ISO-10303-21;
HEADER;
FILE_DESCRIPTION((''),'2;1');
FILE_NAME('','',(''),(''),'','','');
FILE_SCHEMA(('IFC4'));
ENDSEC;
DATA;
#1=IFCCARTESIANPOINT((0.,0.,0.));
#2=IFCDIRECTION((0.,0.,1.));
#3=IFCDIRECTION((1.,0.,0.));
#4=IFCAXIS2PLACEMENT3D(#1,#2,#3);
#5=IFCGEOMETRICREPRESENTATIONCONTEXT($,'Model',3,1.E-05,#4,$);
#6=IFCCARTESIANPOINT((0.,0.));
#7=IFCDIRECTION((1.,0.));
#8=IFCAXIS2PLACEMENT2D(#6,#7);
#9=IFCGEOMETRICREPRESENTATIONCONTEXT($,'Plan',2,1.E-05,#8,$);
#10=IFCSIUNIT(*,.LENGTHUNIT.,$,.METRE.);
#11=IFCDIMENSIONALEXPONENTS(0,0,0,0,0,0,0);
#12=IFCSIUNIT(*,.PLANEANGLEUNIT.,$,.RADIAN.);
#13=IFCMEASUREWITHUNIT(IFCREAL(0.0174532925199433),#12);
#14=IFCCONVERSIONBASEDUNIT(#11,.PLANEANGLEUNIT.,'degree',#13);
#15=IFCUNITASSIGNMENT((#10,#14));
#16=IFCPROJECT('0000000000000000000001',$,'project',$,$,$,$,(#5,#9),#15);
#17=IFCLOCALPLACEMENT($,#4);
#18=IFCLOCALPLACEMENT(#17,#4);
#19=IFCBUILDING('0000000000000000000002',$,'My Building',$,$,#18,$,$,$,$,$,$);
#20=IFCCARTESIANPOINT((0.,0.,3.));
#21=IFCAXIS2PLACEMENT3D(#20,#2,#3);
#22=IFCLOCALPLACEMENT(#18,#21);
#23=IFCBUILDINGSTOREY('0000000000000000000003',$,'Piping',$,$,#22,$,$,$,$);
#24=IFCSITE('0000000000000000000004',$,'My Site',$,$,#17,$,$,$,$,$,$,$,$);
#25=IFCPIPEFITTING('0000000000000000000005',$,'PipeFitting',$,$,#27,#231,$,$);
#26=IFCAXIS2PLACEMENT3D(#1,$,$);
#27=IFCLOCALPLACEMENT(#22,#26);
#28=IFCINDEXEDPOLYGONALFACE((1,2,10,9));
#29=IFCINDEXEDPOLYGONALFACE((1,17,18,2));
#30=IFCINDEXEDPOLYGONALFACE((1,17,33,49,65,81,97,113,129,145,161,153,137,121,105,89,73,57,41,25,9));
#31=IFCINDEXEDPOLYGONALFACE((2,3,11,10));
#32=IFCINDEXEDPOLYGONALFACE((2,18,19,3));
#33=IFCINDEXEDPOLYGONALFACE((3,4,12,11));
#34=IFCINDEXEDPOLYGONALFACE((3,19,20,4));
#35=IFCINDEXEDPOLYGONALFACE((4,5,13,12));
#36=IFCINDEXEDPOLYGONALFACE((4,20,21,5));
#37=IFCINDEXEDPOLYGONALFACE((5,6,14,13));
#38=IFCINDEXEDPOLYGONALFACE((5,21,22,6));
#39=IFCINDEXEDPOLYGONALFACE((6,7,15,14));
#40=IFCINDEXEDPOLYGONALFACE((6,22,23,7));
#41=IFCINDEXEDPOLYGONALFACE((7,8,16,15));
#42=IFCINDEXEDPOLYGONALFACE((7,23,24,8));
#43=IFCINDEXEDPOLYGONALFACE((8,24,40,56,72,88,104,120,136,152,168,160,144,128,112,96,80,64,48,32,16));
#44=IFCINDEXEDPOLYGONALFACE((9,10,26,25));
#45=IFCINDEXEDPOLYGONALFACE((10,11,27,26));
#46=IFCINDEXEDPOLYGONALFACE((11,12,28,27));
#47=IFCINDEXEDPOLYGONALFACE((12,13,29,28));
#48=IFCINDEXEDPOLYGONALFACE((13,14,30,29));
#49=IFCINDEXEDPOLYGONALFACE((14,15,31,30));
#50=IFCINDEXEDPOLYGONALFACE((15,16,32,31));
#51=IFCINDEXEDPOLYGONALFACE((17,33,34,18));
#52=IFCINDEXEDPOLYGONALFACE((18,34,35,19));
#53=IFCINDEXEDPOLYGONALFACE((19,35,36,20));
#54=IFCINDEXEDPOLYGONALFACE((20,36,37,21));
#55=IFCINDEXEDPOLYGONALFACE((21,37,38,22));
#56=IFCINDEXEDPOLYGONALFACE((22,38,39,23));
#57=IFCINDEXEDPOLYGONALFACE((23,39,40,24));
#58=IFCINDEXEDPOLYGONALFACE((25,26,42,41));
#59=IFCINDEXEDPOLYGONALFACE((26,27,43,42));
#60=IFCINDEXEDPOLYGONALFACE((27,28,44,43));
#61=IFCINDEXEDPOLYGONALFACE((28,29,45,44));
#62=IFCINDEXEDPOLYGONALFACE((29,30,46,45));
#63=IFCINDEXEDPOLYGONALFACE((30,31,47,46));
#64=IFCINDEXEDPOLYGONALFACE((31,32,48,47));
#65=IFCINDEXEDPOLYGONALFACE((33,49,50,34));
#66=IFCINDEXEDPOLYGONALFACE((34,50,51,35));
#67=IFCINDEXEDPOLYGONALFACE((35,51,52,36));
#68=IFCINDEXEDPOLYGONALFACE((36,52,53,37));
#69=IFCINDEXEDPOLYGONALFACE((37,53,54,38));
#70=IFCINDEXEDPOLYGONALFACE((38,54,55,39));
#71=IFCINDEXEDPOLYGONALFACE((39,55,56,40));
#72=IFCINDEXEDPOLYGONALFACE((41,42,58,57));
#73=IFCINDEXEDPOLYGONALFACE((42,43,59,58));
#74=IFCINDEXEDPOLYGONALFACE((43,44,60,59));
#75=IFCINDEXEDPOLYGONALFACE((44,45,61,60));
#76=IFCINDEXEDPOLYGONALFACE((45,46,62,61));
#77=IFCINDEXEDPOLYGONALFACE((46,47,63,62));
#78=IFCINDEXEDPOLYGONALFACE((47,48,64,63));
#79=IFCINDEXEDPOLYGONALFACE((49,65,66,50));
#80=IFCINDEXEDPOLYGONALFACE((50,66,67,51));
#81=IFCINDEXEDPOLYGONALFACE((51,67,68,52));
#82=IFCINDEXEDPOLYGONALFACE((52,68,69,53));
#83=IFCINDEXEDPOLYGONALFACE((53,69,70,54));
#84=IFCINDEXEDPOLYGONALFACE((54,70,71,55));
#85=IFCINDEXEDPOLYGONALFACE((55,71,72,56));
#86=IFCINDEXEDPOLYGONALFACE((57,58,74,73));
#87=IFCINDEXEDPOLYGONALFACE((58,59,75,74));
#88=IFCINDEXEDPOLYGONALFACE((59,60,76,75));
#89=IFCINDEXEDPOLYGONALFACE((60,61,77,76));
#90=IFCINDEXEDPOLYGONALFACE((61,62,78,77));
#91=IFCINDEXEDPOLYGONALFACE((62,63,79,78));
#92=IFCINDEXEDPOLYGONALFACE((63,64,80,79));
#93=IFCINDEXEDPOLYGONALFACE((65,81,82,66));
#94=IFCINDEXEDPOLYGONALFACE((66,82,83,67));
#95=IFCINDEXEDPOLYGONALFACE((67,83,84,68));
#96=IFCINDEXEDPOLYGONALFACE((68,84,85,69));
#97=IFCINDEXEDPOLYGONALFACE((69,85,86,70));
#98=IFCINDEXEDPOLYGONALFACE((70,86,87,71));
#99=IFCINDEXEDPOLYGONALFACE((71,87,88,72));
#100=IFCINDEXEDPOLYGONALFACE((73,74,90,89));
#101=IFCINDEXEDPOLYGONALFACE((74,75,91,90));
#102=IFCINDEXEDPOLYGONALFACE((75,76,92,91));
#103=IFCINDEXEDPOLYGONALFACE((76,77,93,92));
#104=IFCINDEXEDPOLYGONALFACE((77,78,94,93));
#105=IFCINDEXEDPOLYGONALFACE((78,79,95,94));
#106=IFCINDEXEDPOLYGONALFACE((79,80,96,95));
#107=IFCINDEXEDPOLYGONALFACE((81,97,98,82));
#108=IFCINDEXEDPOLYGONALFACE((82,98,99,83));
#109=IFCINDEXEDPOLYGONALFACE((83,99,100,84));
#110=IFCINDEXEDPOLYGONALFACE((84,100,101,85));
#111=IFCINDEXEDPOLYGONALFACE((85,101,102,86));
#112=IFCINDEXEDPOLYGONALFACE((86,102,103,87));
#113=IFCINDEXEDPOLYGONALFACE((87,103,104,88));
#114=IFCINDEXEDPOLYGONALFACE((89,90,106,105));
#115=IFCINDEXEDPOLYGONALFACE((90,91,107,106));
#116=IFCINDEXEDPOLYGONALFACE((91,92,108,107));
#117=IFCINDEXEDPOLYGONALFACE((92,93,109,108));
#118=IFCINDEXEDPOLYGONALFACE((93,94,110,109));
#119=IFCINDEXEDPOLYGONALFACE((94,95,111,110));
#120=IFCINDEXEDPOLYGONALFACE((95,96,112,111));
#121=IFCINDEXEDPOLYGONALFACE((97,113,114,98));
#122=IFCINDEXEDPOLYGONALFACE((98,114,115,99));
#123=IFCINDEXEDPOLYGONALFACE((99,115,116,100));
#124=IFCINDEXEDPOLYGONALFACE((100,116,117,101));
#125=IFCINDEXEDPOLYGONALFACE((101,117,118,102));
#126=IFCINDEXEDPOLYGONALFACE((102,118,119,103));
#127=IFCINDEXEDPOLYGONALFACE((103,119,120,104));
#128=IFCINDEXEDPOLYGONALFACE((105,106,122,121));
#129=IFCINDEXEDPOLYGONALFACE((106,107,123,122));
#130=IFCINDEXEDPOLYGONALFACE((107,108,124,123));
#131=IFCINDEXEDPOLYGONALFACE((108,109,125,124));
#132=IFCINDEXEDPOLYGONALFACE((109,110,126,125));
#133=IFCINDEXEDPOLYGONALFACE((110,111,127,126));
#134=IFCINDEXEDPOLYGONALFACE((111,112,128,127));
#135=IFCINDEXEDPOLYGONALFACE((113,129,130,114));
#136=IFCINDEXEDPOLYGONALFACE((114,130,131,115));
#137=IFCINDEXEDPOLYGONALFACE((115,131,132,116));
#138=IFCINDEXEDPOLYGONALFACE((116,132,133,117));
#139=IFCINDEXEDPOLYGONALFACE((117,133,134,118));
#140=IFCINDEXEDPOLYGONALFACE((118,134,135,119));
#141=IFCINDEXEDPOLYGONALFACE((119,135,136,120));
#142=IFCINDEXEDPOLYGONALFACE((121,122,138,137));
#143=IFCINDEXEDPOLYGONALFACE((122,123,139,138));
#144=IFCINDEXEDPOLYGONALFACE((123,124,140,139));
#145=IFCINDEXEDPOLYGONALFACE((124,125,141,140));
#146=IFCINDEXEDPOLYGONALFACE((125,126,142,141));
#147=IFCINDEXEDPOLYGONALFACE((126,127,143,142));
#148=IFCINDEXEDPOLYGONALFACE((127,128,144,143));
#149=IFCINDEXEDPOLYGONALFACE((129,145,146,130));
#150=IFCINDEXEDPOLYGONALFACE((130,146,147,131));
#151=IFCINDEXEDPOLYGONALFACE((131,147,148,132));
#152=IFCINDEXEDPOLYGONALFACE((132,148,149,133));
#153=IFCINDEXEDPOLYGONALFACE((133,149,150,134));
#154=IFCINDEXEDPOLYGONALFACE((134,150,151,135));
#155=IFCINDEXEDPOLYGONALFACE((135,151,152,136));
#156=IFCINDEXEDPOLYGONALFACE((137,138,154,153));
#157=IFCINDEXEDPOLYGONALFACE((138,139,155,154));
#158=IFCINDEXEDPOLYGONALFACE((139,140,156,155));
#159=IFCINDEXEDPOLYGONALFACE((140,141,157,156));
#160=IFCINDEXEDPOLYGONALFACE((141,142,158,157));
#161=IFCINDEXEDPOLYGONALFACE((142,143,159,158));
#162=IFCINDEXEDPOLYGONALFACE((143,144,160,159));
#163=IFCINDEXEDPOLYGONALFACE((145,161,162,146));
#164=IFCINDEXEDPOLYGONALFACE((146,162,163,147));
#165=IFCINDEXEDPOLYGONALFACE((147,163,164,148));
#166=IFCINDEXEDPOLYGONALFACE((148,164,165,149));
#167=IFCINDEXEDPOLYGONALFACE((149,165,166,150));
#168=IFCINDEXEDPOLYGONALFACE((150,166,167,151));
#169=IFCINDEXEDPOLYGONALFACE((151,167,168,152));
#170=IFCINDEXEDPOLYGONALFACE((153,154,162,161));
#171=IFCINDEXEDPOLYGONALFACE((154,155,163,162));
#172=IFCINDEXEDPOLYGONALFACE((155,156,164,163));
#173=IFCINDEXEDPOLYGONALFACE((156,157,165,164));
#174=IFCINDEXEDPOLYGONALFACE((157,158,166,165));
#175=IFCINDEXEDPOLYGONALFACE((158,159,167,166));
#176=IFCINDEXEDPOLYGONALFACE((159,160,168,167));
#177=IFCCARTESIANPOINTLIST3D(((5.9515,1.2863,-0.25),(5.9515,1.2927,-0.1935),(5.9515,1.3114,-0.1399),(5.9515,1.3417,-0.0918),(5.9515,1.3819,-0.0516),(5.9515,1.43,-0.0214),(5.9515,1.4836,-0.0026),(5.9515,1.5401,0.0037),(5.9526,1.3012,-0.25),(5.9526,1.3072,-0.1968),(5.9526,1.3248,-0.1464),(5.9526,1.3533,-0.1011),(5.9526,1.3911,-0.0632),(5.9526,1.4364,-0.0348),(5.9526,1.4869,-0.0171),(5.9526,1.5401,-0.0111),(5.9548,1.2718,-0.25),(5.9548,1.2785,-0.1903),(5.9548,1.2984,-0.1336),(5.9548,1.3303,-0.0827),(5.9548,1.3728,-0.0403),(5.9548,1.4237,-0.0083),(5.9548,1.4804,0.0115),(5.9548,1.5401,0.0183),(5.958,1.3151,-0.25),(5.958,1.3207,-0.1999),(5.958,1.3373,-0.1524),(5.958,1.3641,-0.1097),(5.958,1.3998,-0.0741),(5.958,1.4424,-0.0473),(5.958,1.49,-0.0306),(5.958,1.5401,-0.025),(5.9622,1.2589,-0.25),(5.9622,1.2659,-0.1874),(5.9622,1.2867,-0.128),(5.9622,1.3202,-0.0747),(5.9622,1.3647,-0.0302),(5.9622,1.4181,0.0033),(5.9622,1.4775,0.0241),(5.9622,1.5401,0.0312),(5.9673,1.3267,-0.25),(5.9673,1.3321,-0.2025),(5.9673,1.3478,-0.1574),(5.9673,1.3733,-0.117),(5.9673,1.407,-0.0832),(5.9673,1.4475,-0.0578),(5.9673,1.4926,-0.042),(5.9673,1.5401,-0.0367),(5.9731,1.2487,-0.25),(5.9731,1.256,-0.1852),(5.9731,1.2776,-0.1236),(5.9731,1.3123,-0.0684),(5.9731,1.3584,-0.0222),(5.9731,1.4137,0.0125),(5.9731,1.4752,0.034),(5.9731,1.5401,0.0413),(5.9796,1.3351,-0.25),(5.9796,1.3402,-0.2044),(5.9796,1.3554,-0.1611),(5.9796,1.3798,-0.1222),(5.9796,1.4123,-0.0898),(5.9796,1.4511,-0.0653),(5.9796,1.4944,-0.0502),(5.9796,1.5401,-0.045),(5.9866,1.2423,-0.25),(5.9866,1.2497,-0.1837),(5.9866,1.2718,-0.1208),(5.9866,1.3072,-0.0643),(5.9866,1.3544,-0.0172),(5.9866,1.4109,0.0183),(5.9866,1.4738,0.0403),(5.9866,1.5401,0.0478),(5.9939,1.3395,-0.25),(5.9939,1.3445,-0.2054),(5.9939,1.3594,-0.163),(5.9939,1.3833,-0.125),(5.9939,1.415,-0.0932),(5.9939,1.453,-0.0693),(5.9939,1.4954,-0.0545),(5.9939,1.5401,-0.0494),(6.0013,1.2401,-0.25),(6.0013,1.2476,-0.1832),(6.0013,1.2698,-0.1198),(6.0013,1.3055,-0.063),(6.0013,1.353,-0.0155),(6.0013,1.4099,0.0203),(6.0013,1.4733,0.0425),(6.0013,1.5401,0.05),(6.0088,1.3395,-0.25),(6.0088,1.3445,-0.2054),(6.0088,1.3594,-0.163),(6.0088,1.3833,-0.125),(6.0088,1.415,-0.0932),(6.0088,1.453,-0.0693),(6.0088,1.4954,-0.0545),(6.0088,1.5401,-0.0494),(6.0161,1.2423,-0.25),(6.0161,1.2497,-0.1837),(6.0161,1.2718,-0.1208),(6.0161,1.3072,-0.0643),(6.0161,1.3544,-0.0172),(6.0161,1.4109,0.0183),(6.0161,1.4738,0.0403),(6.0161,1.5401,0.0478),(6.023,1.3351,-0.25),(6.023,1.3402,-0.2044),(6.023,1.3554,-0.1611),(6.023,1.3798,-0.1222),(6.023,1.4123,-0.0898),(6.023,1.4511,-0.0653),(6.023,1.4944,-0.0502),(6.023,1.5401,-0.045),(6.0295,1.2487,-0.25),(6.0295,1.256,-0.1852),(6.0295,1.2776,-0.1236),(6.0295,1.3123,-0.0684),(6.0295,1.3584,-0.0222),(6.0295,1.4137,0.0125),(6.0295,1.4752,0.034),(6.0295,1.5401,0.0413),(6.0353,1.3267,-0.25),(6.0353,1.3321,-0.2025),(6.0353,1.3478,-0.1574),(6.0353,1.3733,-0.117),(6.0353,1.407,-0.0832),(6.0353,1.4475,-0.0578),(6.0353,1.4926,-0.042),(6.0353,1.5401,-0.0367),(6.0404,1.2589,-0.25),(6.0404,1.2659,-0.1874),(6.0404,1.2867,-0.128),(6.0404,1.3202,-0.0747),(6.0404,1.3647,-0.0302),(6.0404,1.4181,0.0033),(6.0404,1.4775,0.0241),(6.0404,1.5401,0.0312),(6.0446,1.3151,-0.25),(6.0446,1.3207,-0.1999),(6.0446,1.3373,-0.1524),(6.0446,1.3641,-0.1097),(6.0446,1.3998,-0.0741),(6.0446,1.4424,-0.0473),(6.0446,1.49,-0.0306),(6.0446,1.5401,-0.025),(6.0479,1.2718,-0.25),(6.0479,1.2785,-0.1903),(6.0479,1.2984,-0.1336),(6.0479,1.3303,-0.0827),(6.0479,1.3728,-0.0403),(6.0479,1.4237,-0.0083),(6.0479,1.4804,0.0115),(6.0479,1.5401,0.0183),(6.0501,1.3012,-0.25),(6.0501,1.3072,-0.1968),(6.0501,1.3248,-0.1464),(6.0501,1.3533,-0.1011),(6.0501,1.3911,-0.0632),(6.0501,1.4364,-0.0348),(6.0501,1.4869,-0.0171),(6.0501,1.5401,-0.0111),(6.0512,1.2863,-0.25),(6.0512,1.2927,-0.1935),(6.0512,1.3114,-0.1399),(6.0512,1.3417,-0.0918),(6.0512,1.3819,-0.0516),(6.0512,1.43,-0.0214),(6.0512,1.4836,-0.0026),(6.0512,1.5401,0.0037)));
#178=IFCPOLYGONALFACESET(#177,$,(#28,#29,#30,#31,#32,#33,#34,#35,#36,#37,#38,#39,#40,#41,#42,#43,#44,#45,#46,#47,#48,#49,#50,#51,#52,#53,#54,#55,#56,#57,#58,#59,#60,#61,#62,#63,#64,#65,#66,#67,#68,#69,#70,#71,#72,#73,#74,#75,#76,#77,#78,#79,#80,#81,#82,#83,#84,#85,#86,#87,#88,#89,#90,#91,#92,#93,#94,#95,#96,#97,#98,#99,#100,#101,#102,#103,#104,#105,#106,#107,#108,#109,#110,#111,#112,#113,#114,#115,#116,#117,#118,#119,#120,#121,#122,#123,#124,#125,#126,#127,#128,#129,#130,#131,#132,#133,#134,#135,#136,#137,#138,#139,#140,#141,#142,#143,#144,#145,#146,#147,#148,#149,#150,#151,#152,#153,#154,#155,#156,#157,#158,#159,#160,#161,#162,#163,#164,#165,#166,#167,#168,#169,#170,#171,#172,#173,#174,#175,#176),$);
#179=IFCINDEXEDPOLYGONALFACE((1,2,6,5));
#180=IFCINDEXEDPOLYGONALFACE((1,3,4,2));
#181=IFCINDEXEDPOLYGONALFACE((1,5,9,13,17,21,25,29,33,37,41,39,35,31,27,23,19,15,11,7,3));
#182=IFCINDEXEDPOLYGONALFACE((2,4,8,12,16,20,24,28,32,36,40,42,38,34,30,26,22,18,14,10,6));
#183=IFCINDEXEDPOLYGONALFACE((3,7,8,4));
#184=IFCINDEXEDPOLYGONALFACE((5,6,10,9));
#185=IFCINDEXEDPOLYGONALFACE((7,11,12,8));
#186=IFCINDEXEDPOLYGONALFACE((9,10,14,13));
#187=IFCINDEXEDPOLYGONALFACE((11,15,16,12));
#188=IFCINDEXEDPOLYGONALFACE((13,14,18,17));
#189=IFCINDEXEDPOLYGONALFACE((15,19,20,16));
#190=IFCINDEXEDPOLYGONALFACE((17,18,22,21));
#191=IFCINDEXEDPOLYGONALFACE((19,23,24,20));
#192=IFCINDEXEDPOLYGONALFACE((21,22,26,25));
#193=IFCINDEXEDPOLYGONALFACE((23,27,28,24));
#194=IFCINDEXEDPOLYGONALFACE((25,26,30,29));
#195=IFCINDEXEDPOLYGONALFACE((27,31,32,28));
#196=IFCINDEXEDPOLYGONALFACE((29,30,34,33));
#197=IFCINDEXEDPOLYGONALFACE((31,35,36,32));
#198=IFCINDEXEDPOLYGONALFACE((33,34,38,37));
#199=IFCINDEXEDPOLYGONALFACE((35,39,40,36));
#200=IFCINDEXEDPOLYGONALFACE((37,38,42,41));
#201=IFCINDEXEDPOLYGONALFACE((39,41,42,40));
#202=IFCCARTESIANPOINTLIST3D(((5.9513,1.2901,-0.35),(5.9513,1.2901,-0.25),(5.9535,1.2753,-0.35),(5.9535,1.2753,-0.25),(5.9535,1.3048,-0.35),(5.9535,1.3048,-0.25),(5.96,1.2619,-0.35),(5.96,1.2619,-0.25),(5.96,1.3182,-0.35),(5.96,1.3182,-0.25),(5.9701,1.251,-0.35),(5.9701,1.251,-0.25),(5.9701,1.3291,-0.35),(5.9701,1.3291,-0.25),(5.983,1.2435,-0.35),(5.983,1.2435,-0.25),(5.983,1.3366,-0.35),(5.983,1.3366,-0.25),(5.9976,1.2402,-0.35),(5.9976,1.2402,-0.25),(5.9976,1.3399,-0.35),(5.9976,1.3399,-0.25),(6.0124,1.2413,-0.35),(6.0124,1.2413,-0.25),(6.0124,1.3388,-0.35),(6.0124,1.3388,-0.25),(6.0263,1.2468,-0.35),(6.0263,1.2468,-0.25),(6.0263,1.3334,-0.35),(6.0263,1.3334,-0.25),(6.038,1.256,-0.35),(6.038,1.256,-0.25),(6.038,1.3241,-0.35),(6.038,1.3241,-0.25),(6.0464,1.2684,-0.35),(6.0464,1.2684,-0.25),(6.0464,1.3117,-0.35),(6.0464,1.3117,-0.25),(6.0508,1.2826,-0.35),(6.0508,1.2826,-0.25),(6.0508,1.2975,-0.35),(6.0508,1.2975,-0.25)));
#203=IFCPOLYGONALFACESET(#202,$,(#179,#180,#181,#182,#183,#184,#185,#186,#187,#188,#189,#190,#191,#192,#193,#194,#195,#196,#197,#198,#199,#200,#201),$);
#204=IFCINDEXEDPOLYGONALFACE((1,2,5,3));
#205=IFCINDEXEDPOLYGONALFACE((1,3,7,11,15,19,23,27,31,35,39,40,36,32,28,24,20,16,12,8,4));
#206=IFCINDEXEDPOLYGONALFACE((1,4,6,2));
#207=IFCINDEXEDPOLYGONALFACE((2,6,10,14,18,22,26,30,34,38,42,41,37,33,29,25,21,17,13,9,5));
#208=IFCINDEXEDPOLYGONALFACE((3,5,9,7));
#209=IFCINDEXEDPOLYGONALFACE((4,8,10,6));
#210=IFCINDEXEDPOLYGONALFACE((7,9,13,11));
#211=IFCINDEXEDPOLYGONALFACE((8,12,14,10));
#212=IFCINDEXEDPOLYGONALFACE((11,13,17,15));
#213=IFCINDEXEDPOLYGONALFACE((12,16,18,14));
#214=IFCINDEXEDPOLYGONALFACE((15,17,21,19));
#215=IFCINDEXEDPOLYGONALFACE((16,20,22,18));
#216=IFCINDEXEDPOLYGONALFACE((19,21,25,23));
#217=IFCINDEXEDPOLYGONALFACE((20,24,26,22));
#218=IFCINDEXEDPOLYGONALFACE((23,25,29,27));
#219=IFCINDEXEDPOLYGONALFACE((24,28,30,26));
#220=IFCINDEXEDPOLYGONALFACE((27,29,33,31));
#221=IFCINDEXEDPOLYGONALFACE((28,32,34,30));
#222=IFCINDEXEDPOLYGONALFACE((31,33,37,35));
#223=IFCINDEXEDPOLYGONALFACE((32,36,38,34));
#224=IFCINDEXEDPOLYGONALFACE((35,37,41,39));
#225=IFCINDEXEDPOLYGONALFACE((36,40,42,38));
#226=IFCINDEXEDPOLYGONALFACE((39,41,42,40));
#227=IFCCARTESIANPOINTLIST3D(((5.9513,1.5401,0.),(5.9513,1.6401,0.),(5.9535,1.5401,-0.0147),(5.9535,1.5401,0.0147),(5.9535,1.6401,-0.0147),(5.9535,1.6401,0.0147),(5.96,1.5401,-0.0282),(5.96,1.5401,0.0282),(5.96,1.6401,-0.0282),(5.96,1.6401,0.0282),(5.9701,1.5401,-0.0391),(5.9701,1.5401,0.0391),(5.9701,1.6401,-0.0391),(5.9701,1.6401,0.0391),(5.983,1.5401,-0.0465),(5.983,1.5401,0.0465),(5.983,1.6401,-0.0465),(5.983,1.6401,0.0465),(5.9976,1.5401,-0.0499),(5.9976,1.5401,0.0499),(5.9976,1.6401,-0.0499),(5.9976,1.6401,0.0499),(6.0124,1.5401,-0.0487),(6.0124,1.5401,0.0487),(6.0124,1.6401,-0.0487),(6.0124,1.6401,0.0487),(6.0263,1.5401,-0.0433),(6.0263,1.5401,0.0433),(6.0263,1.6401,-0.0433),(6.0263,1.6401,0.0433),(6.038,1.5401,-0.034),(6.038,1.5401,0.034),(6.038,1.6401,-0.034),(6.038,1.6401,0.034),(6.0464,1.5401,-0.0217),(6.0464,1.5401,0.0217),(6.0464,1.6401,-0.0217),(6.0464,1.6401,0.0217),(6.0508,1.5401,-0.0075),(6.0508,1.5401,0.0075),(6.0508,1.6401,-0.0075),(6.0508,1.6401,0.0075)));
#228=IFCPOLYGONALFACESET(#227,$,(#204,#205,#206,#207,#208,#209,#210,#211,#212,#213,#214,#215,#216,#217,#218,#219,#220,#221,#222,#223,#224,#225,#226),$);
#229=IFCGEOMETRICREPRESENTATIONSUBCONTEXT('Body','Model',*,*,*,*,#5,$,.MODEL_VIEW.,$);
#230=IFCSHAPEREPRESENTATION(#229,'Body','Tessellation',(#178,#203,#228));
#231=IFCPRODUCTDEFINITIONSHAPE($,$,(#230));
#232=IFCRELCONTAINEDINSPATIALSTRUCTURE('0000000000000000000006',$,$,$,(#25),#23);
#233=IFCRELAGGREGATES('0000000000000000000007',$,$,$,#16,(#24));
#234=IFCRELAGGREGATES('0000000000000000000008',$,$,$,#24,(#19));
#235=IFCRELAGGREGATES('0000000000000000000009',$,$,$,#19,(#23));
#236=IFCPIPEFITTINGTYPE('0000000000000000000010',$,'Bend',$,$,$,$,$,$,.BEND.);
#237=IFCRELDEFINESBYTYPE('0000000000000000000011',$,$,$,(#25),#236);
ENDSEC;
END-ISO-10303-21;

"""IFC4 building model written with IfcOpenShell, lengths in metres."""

from ifc_helpers import new_model, entity, si_unit, converted_unit, frame, origin_with_axes, origin_2d_with_axis, place, context, subcontext, project, spatial, circle, extrude, source, transform, mapped, type_object, type_shapes, element, save


model = new_model("IFC4")

# Units and contexts
model_context = context("Model", 3, precision=1e-05, world=origin_with_axes())
plan_context = context("Plan", 2, precision=1e-05, world=origin_2d_with_axis())
body_context = subcontext(model_context, "Body", "Model", "MODEL_VIEW")
ifc_project = project(units=[si_unit("LENGTHUNIT", "METRE"), converted_unit("PLANEANGLEUNIT", "degree", entity("IfcReal", 0.0174532925199433), si_unit("PLANEANGLEUNIT", "RADIAN"), dimensions=[0, 0, 0, 0, 0, 0, 0])], contexts=[model_context, plan_context])

# Site, building, storey
site_placement = place(None, origin_with_axes())
site = spatial("IfcSite", under=ifc_project, at=site_placement, Name="My Site")
building_placement = place(site_placement, origin_with_axes())
building = spatial("IfcBuilding", under=site, at=building_placement, Name="My Building")
storey_placement = place(building_placement, frame((0.0, 0.0, 3.0), z_axis=(0.0, 0.0, 1.0), x_axis=(1.0, 0.0, 0.0)))
storey = spatial("IfcBuildingStorey", under=building, at=storey_placement, Name="Piping")

# Pipe fitting
pipe_fitting_type_1 = type_object("IfcPipeFittingType", Name="Bend", PredefinedType="BEND")
shared_shape = source(origin_with_axes(), body_context, "Body", "SolidModel", [
    entity("IfcSweptDiskSolid", entity("IfcIndexedPolyCurve", entity("IfcCartesianPointList3D", [[0.0, 0.0, -0.1], [0.0, 0.0732, -0.2768], [0.0, 0.25, -0.35]]), [entity("IfcArcIndex", [1, 2, 3])]), 0.05),
    extrude(circle(Radius=0.05), origin_with_axes(), (0.0, 0.0, -1.0), 0.1),
    extrude(circle(Radius=0.05), frame((0.0, 0.25, -0.35), z_axis=(0.0, 1.0, 0.0), x_axis=(1.0, 0.0, 0.0)), (0.0, 0.0, 1.0), 0.1),
])
type_shapes(pipe_fitting_type_1, [shared_shape])
for number, where, z_axis, x_axis, name in (
    (1, (6.0013, 1.2901, -0.35), (0.0, 0.0, -1.0), (-1.0, 0.0, 0.0), "PipeFitting"),
):
    element("IfcPipeFitting", number, at=place(storey_placement, frame(where, z_axis=z_axis, x_axis=x_axis)), inside=storey, type_object=pipe_fitting_type_1, Name=name, context=body_context, shape_type="MappedRepresentation", body=[
        mapped(shared_shape, transform((0.0, 0.0, 0.0), x_axis=(1.0, 0.0, 0.0), y_axis=(0.0, 1.0, 0.0), z_axis=(0.0, 0.0, 1.0), scale=1.0)),
    ])

save(model, "model.ifc")
